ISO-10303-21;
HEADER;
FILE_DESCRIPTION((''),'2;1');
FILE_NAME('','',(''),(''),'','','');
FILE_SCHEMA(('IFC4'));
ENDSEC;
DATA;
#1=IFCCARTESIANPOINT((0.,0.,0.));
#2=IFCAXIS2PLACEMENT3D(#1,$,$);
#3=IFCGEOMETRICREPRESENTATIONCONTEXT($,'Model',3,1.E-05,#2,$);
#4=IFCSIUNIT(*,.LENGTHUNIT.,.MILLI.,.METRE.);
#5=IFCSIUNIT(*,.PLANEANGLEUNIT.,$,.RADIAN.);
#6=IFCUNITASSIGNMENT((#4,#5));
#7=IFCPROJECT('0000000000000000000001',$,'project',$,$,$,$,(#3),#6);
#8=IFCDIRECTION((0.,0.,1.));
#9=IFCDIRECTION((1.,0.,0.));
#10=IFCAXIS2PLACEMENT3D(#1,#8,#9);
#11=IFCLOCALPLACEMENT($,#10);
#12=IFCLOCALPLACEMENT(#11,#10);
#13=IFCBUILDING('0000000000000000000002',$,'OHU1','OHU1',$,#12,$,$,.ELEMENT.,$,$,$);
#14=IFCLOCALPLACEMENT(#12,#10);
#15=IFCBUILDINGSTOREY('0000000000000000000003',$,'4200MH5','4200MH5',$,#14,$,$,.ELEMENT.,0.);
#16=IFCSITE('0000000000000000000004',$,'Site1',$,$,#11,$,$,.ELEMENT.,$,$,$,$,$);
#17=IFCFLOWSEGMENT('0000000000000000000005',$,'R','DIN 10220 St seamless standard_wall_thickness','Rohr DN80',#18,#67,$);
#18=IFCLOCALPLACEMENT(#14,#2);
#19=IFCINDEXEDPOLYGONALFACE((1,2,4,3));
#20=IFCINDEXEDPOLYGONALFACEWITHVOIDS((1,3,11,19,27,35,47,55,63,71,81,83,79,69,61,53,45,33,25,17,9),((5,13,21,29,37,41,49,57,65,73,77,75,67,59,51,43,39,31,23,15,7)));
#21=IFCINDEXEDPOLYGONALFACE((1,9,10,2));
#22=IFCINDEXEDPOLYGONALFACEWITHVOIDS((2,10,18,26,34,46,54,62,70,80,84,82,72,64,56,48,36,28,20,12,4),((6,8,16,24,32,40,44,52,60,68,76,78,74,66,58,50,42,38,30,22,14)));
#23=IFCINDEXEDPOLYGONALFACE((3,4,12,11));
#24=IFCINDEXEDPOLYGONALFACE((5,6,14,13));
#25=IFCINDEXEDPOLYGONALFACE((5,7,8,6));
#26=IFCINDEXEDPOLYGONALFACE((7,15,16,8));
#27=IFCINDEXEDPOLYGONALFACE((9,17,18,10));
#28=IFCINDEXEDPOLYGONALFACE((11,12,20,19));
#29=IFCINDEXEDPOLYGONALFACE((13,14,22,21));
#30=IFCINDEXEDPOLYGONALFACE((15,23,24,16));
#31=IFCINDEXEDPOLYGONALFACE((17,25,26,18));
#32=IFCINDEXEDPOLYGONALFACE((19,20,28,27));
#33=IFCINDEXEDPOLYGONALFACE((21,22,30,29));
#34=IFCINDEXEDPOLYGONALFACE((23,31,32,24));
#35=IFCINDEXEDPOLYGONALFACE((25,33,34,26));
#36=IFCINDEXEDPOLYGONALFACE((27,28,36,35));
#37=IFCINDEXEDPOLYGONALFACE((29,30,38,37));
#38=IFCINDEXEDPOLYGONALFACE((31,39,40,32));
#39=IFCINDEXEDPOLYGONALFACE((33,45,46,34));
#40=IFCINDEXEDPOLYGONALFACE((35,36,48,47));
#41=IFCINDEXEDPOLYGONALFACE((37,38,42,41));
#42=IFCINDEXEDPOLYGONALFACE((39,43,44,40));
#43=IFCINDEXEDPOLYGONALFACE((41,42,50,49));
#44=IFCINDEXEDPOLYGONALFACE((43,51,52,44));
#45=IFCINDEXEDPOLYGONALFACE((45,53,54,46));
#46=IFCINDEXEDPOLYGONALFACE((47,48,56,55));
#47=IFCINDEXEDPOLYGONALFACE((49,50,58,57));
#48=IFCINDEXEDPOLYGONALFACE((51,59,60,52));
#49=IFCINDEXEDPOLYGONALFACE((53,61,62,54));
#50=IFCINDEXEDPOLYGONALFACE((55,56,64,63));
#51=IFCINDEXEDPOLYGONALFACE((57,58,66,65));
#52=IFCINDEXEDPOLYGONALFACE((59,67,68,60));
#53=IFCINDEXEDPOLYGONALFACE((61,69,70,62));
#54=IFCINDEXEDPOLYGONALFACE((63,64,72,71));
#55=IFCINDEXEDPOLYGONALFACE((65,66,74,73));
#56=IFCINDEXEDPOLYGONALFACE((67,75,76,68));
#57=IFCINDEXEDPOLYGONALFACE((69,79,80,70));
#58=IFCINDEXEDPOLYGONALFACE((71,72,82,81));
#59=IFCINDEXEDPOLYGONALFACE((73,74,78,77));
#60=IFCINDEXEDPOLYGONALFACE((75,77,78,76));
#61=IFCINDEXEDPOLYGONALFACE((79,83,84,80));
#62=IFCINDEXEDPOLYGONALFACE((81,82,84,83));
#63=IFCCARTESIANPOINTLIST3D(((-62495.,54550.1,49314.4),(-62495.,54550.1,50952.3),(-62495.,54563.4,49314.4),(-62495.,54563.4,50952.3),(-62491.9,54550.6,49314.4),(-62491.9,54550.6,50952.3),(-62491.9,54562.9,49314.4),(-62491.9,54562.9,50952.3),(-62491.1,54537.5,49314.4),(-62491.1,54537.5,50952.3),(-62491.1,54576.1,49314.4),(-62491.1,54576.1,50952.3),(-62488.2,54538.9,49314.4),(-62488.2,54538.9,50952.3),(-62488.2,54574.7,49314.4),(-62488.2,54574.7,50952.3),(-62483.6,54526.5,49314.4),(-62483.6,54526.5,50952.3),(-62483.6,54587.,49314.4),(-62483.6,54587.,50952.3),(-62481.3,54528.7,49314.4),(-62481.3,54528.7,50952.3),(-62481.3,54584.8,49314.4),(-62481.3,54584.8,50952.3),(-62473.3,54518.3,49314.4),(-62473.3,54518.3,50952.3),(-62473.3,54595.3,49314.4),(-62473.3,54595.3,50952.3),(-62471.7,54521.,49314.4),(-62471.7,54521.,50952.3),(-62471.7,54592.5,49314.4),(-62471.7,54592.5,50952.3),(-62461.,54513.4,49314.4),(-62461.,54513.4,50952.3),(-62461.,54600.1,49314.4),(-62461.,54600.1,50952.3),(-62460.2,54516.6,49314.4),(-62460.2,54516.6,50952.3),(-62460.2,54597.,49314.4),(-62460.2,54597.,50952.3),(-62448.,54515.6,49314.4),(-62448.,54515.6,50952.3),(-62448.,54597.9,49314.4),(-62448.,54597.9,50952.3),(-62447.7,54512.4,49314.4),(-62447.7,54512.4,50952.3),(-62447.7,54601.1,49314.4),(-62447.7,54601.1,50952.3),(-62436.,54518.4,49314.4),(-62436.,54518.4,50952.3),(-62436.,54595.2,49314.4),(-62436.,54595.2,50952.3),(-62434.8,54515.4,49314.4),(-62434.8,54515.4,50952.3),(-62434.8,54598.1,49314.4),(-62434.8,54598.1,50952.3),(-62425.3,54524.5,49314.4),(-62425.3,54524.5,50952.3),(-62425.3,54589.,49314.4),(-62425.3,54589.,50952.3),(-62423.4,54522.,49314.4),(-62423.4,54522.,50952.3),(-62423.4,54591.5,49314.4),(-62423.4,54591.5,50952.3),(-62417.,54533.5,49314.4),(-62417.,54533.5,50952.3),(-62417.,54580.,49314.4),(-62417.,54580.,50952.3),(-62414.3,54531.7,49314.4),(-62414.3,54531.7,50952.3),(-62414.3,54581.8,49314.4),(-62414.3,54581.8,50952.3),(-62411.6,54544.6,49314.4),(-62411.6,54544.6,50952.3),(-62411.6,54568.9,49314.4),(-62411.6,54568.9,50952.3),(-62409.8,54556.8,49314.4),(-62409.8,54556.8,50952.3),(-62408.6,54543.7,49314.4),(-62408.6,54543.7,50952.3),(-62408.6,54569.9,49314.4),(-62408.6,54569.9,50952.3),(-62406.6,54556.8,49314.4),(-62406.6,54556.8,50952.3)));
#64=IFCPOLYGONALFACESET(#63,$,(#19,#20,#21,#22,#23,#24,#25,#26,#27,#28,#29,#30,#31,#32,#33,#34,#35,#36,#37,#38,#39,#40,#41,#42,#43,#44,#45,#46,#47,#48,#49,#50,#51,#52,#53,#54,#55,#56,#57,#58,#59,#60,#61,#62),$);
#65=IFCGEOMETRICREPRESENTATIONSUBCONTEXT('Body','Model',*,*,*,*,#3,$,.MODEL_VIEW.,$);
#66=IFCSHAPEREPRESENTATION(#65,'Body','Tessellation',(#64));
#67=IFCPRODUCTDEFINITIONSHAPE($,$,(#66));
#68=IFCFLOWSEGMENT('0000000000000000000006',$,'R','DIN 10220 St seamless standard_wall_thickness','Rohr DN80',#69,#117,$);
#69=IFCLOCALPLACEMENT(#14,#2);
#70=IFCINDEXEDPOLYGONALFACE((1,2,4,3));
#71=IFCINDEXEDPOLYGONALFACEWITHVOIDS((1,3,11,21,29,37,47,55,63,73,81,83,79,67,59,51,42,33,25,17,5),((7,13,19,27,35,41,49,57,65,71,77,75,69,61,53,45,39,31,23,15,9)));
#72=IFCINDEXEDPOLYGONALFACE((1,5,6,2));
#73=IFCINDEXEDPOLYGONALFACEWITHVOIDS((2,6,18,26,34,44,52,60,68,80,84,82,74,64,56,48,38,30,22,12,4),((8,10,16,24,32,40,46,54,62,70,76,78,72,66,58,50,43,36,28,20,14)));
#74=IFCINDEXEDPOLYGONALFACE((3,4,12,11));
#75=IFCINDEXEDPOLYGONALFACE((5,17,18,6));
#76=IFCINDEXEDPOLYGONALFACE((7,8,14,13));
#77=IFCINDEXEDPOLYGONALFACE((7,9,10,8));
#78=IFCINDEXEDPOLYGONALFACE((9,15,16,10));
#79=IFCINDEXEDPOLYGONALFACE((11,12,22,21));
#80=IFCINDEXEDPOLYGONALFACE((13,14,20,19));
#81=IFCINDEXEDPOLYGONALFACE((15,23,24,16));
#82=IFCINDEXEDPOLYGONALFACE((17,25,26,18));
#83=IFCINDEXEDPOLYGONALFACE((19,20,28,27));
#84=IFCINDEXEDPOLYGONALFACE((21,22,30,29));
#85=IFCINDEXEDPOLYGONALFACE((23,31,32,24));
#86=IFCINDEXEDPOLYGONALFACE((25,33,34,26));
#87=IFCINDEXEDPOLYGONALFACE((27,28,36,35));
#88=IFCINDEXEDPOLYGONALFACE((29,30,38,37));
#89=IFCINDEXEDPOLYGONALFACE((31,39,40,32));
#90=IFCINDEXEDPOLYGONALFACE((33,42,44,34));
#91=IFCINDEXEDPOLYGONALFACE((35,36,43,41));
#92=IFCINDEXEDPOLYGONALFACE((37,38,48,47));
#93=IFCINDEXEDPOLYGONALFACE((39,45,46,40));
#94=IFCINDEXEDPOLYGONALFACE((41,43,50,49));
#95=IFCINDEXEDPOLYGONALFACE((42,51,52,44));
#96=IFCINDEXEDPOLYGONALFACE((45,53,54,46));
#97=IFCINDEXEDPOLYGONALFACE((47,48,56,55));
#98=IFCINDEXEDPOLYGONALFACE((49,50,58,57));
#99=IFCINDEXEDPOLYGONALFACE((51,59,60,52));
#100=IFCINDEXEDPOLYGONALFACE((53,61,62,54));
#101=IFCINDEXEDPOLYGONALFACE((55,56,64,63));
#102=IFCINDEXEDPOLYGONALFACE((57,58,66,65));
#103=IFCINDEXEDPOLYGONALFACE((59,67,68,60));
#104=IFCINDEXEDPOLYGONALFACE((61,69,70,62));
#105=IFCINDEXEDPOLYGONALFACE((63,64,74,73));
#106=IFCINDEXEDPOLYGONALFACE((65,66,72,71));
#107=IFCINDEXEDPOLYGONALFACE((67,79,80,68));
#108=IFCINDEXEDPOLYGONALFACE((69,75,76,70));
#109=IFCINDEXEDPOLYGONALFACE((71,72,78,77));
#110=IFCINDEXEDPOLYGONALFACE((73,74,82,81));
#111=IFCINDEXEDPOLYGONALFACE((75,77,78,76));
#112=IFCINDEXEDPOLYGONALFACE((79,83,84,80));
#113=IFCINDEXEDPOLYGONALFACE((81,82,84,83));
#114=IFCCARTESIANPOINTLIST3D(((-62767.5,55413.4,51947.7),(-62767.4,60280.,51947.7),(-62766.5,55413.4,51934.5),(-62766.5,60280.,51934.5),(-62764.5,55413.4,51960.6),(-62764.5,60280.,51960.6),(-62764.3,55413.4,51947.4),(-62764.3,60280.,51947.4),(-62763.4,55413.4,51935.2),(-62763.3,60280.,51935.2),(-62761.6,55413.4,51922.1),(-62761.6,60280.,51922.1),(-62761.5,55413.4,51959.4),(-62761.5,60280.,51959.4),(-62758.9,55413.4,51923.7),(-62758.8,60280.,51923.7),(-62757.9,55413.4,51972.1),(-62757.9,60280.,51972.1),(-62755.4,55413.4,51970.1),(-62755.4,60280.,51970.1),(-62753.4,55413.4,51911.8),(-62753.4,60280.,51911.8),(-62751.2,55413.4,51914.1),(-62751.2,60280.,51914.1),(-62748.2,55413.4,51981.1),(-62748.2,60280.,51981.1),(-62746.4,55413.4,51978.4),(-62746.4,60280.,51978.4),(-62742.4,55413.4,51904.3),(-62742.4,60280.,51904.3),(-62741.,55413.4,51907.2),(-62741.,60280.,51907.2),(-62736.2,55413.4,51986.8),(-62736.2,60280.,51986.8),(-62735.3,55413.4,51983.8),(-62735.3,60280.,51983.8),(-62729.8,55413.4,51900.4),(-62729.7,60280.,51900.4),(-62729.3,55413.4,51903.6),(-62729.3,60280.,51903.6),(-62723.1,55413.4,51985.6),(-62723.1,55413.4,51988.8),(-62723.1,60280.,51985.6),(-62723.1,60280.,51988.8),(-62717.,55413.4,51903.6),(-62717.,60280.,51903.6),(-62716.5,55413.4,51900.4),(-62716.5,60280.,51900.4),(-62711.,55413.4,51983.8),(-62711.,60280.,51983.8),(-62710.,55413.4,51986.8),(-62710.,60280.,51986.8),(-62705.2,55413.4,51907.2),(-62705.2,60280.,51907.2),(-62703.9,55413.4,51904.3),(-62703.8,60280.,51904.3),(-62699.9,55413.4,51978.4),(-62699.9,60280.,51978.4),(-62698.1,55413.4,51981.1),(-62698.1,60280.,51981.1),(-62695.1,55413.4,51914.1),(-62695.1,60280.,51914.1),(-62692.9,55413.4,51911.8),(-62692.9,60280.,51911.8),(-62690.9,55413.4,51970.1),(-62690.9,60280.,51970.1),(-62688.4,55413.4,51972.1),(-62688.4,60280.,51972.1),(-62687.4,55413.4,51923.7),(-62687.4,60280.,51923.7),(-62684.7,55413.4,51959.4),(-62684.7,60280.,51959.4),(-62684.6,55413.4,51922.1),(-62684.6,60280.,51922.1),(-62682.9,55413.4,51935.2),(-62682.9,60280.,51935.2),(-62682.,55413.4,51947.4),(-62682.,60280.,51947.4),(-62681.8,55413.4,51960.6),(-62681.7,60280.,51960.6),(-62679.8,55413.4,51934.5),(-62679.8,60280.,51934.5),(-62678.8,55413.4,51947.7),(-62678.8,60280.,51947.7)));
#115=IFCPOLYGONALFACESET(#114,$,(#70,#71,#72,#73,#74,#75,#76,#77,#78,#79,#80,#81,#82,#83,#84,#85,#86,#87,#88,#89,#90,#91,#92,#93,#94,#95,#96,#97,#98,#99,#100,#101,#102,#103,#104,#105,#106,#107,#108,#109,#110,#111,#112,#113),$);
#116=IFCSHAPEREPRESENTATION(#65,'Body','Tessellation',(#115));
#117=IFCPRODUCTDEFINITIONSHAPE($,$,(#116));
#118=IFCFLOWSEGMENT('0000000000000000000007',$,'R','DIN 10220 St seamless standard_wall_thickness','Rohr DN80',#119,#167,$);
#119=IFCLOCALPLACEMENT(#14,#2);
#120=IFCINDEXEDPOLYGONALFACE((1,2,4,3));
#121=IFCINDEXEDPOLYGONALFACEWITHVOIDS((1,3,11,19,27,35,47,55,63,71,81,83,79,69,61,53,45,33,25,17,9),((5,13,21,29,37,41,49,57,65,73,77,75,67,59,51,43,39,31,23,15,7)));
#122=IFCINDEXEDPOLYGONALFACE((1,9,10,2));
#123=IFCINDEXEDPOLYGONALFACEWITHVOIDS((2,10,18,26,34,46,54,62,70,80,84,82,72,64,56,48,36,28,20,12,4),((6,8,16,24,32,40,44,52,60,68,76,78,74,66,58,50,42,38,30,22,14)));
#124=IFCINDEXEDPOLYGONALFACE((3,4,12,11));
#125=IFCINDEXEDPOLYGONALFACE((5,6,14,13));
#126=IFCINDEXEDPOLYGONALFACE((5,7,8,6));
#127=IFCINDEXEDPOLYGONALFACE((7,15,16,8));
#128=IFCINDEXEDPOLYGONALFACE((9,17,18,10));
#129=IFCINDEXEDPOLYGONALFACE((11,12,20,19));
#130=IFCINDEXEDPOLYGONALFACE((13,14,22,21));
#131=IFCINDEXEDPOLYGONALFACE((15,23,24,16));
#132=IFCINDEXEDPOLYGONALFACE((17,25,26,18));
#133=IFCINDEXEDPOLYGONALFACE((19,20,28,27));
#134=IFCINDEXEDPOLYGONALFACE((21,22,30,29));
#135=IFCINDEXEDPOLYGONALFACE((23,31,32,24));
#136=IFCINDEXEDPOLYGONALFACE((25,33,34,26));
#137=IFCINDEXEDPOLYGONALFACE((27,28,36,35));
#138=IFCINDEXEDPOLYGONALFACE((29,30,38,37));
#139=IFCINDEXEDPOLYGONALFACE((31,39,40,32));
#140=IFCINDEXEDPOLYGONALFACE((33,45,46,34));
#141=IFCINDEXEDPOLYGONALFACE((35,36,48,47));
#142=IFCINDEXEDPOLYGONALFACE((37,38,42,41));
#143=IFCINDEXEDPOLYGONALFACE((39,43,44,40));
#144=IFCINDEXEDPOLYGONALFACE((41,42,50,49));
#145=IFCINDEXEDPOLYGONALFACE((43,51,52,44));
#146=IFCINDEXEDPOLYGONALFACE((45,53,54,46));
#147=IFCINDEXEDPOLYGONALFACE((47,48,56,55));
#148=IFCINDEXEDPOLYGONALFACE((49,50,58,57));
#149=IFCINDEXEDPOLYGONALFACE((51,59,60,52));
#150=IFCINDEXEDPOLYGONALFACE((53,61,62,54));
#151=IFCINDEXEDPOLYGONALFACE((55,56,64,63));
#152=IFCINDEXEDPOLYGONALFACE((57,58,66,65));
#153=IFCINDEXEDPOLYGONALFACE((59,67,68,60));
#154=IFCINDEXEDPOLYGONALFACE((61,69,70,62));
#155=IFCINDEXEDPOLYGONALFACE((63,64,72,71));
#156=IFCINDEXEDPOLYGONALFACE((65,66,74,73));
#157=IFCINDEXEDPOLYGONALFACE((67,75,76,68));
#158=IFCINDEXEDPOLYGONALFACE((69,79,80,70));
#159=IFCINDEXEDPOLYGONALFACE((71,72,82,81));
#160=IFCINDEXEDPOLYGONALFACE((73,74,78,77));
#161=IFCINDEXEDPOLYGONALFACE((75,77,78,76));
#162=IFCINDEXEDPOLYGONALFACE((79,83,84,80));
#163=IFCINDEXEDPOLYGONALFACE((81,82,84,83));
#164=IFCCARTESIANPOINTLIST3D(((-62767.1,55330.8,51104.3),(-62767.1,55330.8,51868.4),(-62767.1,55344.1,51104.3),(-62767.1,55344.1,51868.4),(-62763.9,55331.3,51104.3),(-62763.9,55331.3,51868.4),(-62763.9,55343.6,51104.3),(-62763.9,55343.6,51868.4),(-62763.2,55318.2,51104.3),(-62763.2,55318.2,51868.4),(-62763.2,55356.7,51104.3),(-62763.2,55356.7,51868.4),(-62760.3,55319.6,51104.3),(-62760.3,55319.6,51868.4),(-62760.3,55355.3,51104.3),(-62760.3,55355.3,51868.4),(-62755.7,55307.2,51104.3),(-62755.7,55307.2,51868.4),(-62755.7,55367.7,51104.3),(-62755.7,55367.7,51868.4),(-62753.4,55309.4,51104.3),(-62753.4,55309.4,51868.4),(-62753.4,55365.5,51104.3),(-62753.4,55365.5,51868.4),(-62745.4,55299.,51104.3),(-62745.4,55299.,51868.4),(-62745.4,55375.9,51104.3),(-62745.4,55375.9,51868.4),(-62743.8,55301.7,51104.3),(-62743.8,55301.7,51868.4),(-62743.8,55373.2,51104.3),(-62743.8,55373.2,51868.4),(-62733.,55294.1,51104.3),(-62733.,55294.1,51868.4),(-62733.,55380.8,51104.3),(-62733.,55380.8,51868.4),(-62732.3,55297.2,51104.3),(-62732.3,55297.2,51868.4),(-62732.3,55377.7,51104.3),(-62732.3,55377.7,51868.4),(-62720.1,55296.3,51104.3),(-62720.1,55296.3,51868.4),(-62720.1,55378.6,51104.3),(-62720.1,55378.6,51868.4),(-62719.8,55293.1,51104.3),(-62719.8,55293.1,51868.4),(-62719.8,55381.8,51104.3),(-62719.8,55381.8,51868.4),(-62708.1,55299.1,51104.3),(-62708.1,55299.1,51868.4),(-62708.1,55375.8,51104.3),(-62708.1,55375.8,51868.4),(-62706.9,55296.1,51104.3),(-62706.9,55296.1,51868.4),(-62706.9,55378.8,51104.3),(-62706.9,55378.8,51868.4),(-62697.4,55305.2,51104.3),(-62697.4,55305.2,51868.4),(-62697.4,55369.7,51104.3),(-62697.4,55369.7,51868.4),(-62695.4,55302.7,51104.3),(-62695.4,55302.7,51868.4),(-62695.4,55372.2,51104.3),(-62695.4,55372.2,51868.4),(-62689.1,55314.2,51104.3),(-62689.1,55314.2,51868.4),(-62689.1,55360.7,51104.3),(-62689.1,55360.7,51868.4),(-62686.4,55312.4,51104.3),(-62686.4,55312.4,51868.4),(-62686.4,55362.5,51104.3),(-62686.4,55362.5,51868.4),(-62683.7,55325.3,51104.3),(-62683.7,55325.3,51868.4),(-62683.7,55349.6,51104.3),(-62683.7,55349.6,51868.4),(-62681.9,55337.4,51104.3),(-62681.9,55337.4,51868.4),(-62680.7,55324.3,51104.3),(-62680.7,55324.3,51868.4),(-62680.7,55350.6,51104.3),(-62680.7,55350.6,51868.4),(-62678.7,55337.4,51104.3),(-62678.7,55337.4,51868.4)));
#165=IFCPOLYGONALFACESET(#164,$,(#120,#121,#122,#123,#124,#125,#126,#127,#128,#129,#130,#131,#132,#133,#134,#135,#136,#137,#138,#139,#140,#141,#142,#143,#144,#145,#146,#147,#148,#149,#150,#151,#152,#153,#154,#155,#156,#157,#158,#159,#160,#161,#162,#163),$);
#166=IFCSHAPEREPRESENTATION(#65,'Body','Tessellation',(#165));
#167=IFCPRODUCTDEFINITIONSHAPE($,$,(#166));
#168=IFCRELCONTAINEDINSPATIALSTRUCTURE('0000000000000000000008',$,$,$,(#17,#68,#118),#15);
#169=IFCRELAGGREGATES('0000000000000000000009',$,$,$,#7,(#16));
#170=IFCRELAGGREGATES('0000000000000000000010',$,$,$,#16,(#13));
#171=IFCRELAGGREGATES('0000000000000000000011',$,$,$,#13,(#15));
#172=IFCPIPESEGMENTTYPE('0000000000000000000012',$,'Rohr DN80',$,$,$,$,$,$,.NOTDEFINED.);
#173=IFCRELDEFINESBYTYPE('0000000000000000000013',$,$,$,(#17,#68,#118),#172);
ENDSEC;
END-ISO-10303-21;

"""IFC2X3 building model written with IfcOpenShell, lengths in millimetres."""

from ifc_helpers import new_model, si_unit, frame, origin, origin_with_axes, origin_2d_with_axis, place, context, subcontext, project, spatial, hollow_circle, extrude, type_object, element, save


model = new_model("IFC2X3")

# Units and contexts
model_context = context("Model", 3, precision=1e-05, world=origin())
body_context = subcontext(model_context, "Body", "Model", "MODEL_VIEW")
ifc_project = project(units=[si_unit("LENGTHUNIT", "METRE", prefix="MILLI"), si_unit("PLANEANGLEUNIT", "RADIAN")], contexts=[model_context])

# Site, building, storey
site_placement = place(None, origin_with_axes())
site = spatial("IfcSite", under=ifc_project, at=site_placement, Name="Site1", CompositionType="ELEMENT")
building_placement = place(site_placement, origin_with_axes())
building = spatial("IfcBuilding", under=site, at=building_placement, Name="OHU1", Description="OHU1", CompositionType="ELEMENT")
storey_placement = place(building_placement, origin_with_axes())
storey = spatial("IfcBuildingStorey", under=building, at=storey_placement, Name="4200MH5", Description="4200MH5", CompositionType="ELEMENT", Elevation=0.0)

# Flow segments
pipe_segment_type_1 = type_object("IfcPipeSegmentType", Name="Rohr DN80", PredefinedType="NOTDEFINED")
flow_segment_1_placement = place(storey_placement, frame((-62451.1, 54556.8, 50133.4), z_axis=(0.0, 0.0, 1.0), x_axis=(1.0, 0.0, 0.0)))
element("IfcFlowSegment", 1, at=flow_segment_1_placement, inside=storey, type_object=pipe_segment_type_1, Name="R", Description="DIN 10220 St seamless standard_wall_thickness", ObjectType="Rohr DN80", context=body_context, shape_type="SweptSolid", body=[
    extrude(hollow_circle(Radius=44.5, WallThickness=3.2, at=origin_2d_with_axis()), frame((0.0, 0.0, -818.9), z_axis=(0.0, 0.0, 1.0), x_axis=(1.0, 0.0, 0.0)), (0.0, 0.0, 1.0), 1637.8),
])
flow_segment_2_placement = place(storey_placement, frame((-62723.1, 57846.7, 51944.4), z_axis=(0.0, 0.0, 1.0), x_axis=(1.0, 0.0, 0.0)))
element("IfcFlowSegment", 2, at=flow_segment_2_placement, inside=storey, type_object=pipe_segment_type_1, Name="R", Description="DIN 10220 St seamless standard_wall_thickness", ObjectType="Rohr DN80", context=body_context, shape_type="SweptSolid", body=[
    extrude(hollow_circle(Radius=44.5, WallThickness=3.2, at=origin_2d_with_axis()), frame((0.0, -2433.3, 0.0), z_axis=(0.000003, 1.0, 0.0), x_axis=(0.0, 0.0, 1.0)), (0.0, 0.0, 1.0), 4866.5),
])
flow_segment_3_placement = place(storey_placement, frame((-62723.1, 55337.4, 51486.3), z_axis=(0.0, 0.0, 1.0), x_axis=(1.0, 0.0, 0.0)))
element("IfcFlowSegment", 3, at=flow_segment_3_placement, inside=storey, type_object=pipe_segment_type_1, Name="R", Description="DIN 10220 St seamless standard_wall_thickness", ObjectType="Rohr DN80", context=body_context, shape_type="SweptSolid", body=[
    extrude(hollow_circle(Radius=44.5, WallThickness=3.2, at=origin_2d_with_axis()), frame((0.0, 0.0, 382.1), z_axis=(0.0, 0.0, -1.0), x_axis=(1.0, 0.0, 0.0)), (0.0, 0.0, 1.0), 764.1),
])

save(model, "model.ifc")
